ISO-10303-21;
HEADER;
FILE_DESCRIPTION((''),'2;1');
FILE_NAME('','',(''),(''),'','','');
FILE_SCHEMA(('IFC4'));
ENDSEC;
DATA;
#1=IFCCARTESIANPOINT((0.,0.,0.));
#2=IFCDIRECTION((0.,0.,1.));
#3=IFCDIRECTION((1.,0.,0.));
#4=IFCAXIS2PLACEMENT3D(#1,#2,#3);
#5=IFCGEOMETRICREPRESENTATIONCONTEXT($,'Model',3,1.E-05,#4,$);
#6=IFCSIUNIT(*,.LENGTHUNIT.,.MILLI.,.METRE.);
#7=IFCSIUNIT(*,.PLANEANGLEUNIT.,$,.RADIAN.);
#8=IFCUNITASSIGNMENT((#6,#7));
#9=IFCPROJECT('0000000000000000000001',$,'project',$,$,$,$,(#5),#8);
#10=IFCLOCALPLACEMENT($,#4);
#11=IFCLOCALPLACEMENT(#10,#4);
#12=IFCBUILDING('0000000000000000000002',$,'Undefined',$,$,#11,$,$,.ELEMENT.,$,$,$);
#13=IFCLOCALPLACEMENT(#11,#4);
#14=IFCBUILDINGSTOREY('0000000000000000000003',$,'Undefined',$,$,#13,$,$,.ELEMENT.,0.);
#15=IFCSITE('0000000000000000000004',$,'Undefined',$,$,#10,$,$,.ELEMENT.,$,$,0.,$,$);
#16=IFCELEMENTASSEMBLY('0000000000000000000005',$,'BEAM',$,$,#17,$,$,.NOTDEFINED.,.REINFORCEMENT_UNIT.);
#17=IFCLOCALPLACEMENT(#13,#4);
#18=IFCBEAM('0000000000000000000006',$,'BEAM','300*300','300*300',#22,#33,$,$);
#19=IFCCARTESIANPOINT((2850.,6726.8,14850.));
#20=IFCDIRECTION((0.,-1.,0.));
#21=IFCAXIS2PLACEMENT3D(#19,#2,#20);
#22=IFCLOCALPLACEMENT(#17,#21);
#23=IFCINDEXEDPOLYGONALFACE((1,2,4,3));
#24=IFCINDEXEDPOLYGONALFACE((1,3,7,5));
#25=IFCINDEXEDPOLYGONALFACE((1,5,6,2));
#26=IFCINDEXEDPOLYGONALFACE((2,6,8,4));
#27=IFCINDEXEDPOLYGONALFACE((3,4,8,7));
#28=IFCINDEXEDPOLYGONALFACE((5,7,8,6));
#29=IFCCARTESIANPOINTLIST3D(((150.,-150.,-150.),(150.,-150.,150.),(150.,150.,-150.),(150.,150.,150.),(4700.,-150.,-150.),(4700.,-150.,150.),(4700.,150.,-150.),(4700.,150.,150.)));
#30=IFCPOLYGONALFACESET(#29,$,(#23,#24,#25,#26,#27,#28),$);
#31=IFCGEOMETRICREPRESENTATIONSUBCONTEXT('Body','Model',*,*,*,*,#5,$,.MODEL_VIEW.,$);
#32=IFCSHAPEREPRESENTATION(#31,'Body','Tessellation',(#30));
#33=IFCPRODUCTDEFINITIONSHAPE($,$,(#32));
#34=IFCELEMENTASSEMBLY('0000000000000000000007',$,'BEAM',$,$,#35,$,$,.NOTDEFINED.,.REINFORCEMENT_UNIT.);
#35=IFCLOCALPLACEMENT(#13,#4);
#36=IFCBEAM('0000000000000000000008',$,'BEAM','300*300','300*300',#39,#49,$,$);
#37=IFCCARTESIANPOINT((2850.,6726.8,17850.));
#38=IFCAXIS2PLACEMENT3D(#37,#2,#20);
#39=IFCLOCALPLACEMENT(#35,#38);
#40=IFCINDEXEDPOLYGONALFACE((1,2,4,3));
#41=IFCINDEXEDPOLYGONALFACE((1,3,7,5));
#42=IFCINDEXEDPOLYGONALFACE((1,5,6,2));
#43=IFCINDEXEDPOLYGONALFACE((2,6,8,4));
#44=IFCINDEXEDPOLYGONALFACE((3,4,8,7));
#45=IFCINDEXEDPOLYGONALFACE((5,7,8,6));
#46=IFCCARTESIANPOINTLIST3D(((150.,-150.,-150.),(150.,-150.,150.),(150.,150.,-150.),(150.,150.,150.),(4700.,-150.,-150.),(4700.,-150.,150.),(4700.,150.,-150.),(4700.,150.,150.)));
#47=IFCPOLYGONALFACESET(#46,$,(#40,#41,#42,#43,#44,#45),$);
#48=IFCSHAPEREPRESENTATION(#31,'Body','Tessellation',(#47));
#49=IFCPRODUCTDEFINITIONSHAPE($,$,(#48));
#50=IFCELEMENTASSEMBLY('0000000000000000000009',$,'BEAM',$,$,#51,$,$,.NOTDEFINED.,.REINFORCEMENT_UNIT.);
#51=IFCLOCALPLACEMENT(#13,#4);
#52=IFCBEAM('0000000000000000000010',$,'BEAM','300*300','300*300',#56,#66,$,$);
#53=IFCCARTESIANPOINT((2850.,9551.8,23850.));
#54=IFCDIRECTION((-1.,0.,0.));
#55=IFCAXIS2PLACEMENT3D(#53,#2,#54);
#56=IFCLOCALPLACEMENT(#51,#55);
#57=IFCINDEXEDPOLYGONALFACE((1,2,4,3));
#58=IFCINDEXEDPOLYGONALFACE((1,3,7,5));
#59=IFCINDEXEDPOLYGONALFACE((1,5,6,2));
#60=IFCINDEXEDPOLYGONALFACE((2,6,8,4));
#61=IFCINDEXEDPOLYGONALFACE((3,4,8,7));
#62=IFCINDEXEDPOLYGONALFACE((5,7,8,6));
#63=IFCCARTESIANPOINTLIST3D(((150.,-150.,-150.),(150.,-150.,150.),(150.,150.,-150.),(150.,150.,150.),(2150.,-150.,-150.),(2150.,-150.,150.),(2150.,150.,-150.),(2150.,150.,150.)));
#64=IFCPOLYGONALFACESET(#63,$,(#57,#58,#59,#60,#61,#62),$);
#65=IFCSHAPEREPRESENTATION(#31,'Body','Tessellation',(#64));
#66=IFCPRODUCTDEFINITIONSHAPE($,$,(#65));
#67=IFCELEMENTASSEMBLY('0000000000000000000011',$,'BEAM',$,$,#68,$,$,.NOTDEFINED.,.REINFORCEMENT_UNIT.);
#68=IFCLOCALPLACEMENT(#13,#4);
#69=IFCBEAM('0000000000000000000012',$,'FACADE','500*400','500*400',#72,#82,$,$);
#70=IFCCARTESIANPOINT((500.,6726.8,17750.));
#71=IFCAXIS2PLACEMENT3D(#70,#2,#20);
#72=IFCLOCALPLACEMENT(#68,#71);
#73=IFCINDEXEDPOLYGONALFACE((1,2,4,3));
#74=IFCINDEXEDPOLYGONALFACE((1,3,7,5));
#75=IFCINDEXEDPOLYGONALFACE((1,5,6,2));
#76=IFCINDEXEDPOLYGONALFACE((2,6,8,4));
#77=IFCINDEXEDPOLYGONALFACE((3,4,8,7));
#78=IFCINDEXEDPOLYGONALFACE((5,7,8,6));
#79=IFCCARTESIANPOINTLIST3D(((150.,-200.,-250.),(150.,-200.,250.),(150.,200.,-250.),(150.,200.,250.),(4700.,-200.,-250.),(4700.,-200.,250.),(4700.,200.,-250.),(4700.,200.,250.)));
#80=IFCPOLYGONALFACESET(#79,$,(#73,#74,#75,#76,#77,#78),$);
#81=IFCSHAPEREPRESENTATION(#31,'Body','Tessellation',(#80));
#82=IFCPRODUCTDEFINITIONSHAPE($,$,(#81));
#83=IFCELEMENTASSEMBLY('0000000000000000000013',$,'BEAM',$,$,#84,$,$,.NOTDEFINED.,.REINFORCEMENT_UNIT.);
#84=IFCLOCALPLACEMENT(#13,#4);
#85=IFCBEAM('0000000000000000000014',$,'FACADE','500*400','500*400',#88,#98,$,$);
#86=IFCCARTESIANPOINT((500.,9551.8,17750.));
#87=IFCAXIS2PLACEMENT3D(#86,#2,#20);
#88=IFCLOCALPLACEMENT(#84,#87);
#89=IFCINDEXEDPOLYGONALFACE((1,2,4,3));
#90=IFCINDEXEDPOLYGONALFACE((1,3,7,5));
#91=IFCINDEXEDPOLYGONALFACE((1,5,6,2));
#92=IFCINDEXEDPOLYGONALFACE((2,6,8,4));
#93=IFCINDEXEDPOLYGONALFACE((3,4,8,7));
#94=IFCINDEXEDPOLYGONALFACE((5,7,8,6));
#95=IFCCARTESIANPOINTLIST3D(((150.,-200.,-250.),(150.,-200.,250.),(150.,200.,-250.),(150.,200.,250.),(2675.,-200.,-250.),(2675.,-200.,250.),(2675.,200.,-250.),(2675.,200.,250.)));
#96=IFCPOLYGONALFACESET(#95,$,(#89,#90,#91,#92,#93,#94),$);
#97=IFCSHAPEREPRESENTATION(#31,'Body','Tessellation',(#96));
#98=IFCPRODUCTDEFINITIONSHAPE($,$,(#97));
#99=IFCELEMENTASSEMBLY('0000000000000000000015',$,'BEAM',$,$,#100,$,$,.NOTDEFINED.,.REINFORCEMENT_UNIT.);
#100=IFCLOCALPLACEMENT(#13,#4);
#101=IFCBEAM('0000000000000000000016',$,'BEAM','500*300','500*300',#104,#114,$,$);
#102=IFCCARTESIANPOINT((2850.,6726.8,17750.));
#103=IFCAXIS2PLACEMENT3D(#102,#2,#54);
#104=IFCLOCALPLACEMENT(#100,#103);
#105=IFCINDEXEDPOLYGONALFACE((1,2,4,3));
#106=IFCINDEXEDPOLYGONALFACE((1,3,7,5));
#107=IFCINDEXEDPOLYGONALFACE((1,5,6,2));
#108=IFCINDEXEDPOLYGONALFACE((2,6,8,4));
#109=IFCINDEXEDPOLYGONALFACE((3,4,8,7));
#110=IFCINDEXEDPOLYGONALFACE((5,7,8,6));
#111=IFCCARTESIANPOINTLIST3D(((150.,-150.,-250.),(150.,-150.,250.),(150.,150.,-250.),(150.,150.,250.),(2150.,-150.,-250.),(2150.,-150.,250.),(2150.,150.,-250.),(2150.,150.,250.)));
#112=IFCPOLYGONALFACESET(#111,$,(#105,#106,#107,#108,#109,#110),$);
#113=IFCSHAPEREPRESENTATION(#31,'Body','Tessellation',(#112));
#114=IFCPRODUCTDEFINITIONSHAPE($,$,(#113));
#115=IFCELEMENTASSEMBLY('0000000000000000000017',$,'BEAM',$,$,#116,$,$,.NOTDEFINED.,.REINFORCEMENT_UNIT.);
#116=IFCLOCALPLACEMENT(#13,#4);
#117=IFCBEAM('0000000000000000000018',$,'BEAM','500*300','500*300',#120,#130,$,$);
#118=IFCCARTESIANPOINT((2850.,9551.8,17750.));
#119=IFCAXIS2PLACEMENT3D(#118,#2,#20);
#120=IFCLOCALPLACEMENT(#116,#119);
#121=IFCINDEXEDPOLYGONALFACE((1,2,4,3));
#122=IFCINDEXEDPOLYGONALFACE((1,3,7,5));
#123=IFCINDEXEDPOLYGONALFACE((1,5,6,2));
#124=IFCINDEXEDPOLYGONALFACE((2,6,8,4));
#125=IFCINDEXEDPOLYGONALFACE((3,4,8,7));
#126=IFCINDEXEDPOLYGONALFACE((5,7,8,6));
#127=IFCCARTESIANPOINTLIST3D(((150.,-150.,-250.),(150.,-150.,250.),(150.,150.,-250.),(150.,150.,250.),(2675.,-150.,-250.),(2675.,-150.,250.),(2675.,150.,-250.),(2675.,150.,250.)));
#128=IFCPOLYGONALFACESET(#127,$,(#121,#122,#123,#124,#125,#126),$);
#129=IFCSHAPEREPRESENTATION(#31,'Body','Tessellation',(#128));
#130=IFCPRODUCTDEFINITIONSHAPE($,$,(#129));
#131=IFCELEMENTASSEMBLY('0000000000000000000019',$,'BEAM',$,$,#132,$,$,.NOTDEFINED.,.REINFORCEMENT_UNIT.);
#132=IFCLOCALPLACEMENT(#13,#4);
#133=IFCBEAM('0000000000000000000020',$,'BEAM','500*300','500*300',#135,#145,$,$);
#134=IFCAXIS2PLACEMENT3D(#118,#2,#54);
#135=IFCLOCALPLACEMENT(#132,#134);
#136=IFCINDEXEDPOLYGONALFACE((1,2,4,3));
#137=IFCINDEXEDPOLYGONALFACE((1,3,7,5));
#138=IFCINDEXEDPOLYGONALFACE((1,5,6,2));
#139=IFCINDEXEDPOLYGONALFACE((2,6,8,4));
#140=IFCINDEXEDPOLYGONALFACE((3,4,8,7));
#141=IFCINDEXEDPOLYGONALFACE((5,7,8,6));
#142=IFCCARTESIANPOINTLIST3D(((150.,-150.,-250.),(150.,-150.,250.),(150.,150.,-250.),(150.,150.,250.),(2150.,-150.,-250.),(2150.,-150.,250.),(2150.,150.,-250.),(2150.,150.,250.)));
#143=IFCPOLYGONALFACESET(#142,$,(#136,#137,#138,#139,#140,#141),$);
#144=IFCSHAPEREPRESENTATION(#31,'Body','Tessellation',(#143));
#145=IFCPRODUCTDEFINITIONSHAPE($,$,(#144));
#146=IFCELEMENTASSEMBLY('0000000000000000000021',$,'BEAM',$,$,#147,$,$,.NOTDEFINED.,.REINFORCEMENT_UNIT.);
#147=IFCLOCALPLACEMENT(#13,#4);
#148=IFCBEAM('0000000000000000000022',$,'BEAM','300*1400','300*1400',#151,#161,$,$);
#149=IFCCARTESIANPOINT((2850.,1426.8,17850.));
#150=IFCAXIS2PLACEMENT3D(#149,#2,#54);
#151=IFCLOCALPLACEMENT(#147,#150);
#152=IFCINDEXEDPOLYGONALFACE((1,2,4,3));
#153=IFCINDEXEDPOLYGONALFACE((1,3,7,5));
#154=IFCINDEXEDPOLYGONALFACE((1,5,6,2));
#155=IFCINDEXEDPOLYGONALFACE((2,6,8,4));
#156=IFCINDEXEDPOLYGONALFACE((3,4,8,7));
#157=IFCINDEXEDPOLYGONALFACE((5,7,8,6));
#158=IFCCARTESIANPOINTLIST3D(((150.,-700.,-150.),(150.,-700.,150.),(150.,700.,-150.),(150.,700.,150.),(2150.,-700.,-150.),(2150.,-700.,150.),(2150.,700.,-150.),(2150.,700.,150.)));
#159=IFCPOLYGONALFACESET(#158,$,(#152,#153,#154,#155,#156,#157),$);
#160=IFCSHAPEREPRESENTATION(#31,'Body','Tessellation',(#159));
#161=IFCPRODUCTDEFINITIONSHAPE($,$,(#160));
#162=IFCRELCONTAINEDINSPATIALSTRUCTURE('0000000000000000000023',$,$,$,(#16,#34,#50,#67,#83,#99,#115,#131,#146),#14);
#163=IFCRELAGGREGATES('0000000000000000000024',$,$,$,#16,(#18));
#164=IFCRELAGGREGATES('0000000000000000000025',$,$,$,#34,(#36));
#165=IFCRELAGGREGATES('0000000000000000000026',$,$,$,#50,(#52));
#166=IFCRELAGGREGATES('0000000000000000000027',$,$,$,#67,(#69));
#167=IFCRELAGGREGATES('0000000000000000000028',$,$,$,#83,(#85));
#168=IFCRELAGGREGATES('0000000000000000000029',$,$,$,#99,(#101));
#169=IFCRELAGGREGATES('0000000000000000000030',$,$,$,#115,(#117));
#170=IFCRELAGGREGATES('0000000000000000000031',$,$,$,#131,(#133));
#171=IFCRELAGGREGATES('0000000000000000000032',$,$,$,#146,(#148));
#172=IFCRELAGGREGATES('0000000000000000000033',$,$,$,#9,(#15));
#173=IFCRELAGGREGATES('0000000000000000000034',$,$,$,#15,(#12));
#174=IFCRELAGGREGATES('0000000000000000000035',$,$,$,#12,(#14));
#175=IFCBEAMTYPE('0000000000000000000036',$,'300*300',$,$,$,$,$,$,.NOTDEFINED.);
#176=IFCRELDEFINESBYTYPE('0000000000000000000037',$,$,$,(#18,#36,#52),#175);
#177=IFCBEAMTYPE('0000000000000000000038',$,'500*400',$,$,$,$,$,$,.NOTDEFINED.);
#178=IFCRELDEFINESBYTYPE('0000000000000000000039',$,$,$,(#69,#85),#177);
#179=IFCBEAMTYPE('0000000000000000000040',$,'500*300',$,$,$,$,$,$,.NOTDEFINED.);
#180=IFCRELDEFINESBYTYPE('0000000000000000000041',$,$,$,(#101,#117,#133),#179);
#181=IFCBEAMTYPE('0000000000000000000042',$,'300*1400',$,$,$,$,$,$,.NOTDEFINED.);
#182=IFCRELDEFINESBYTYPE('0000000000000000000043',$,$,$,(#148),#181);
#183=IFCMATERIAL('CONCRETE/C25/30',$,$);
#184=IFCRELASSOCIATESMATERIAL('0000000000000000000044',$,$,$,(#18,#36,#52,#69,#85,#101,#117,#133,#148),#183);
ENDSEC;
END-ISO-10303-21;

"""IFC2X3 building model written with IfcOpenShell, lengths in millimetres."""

from ifc_helpers import new_model, si_unit, frame, origin_with_axes, origin_2d_with_axis, place, context, subcontext, project, spatial, rectangle, extrude, material, type_object, element, aggregate, save


model = new_model("IFC2X3")

# Units and contexts
model_context = context("Model", 3, precision=1e-05, world=origin_with_axes())
body_context = subcontext(model_context, "Body", "Model", "MODEL_VIEW")
ifc_project = project(units=[si_unit("LENGTHUNIT", "METRE", prefix="MILLI"), si_unit("PLANEANGLEUNIT", "RADIAN")], contexts=[model_context])

# Site, building, storey
site_placement = place(None, origin_with_axes())
site = spatial("IfcSite", under=ifc_project, at=site_placement, Name="Undefined", CompositionType="ELEMENT", RefElevation=0.0)
building_placement = place(site_placement, origin_with_axes())
building = spatial("IfcBuilding", under=site, at=building_placement, Name="Undefined", CompositionType="ELEMENT")
storey_placement = place(building_placement, origin_with_axes())
storey = spatial("IfcBuildingStorey", under=building, at=storey_placement, Name="Undefined", CompositionType="ELEMENT", Elevation=0.0)

# Shared definitions
ifc_material_1 = material(Name="CONCRETE/C25/30")

# Element assemblies, beams
assembly_1_placement = place(storey_placement, origin_with_axes())
assembly_1 = element("IfcElementAssembly", 1, at=assembly_1_placement, inside=storey, Name="BEAM", AssemblyPlace="NOTDEFINED", PredefinedType="REINFORCEMENT_UNIT")
beam_type_1 = type_object("IfcBeamType", Name="300*300", PredefinedType="NOTDEFINED")
beam_1_placement = place(assembly_1_placement, frame((2850.0, 6726.8, 14850.0), z_axis=(0.0, 0.0, 1.0), x_axis=(0.0, -1.0, 0.0)))
beam_1 = element("IfcBeam", 2, at=beam_1_placement, type_object=beam_type_1, material=ifc_material_1, Name="BEAM", Description="300*300", ObjectType="300*300", context=body_context, shape_type="SweptSolid", body=[
    extrude(rectangle(XDim=300.0, YDim=300.0, at=origin_2d_with_axis()), frame((4700.0, 0.0, 0.0), z_axis=(-1.0, 0.0, 0.0), x_axis=(0.0, -1.0, 0.0)), (0.0, 0.0, 1.0), 4550.0),
])
aggregate(assembly_1, [beam_1])
assembly_2_placement = place(storey_placement, origin_with_axes())
assembly_2 = element("IfcElementAssembly", 3, at=assembly_2_placement, inside=storey, Name="BEAM", AssemblyPlace="NOTDEFINED", PredefinedType="REINFORCEMENT_UNIT")
beam_2_placement = place(assembly_2_placement, frame((2850.0, 6726.8, 17850.0), z_axis=(0.0, 0.0, 1.0), x_axis=(0.0, -1.0, 0.0)))
beam_2 = element("IfcBeam", 4, at=beam_2_placement, type_object=beam_type_1, material=ifc_material_1, Name="BEAM", Description="300*300", ObjectType="300*300", context=body_context, shape_type="SweptSolid", body=[
    extrude(rectangle(XDim=300.0, YDim=300.0, at=origin_2d_with_axis()), frame((4700.0, 0.0, 0.0), z_axis=(-1.0, 0.0, 0.0), x_axis=(0.0, -1.0, 0.0)), (0.0, 0.0, 1.0), 4550.0),
])
aggregate(assembly_2, [beam_2])
assembly_3_placement = place(storey_placement, origin_with_axes())
assembly_3 = element("IfcElementAssembly", 5, at=assembly_3_placement, inside=storey, Name="BEAM", AssemblyPlace="NOTDEFINED", PredefinedType="REINFORCEMENT_UNIT")
beam_3_placement = place(assembly_3_placement, frame((2850.0, 9551.8, 23850.0), z_axis=(0.0, 0.0, 1.0), x_axis=(-1.0, 0.0, 0.0)))
beam_3 = element("IfcBeam", 6, at=beam_3_placement, type_object=beam_type_1, material=ifc_material_1, Name="BEAM", Description="300*300", ObjectType="300*300", context=body_context, shape_type="SweptSolid", body=[
    extrude(rectangle(XDim=300.0, YDim=300.0, at=origin_2d_with_axis()), frame((2150.0, 0.0, 0.0), z_axis=(-1.0, 0.0, 0.0), x_axis=(0.0, -1.0, 0.0)), (0.0, 0.0, 1.0), 2000.0),
])
aggregate(assembly_3, [beam_3])
assembly_4_placement = place(storey_placement, origin_with_axes())
assembly_4 = element("IfcElementAssembly", 7, at=assembly_4_placement, inside=storey, Name="BEAM", AssemblyPlace="NOTDEFINED", PredefinedType="REINFORCEMENT_UNIT")
beam_type_2 = type_object("IfcBeamType", Name="500*400", PredefinedType="NOTDEFINED")
beam_4_placement = place(assembly_4_placement, frame((500.0, 6726.8, 17750.0), z_axis=(0.0, 0.0, 1.0), x_axis=(0.0, -1.0, 0.0)))
beam_4 = element("IfcBeam", 8, at=beam_4_placement, type_object=beam_type_2, material=ifc_material_1, Name="FACADE", Description="500*400", ObjectType="500*400", context=body_context, shape_type="SweptSolid", body=[
    extrude(rectangle(XDim=400.0, YDim=500.0, at=origin_2d_with_axis()), frame((4700.0, 0.0, 0.0), z_axis=(-1.0, 0.0, 0.0), x_axis=(0.0, -1.0, 0.0)), (0.0, 0.0, 1.0), 4550.0),
])
aggregate(assembly_4, [beam_4])
assembly_5_placement = place(storey_placement, origin_with_axes())
assembly_5 = element("IfcElementAssembly", 9, at=assembly_5_placement, inside=storey, Name="BEAM", AssemblyPlace="NOTDEFINED", PredefinedType="REINFORCEMENT_UNIT")
beam_5_placement = place(assembly_5_placement, frame((500.0, 9551.8, 17750.0), z_axis=(0.0, 0.0, 1.0), x_axis=(0.0, -1.0, 0.0)))
beam_5 = element("IfcBeam", 10, at=beam_5_placement, type_object=beam_type_2, material=ifc_material_1, Name="FACADE", Description="500*400", ObjectType="500*400", context=body_context, shape_type="SweptSolid", body=[
    extrude(rectangle(XDim=400.0, YDim=500.0, at=origin_2d_with_axis()), frame((2675.0, 0.0, 0.0), z_axis=(-1.0, 0.0, 0.0), x_axis=(0.0, -1.0, 0.0)), (0.0, 0.0, 1.0), 2525.0),
])
aggregate(assembly_5, [beam_5])
assembly_6_placement = place(storey_placement, origin_with_axes())
assembly_6 = element("IfcElementAssembly", 11, at=assembly_6_placement, inside=storey, Name="BEAM", AssemblyPlace="NOTDEFINED", PredefinedType="REINFORCEMENT_UNIT")
beam_type_3 = type_object("IfcBeamType", Name="500*300", PredefinedType="NOTDEFINED")
beam_6_placement = place(assembly_6_placement, frame((2850.0, 6726.8, 17750.0), z_axis=(0.0, 0.0, 1.0), x_axis=(-1.0, 0.0, 0.0)))
beam_6 = element("IfcBeam", 12, at=beam_6_placement, type_object=beam_type_3, material=ifc_material_1, Name="BEAM", Description="500*300", ObjectType="500*300", context=body_context, shape_type="SweptSolid", body=[
    extrude(rectangle(XDim=300.0, YDim=500.0, at=origin_2d_with_axis()), frame((2150.0, 0.0, 0.0), z_axis=(-1.0, 0.0, 0.0), x_axis=(0.0, -1.0, 0.0)), (0.0, 0.0, 1.0), 2000.0),
])
aggregate(assembly_6, [beam_6])
assembly_7_placement = place(storey_placement, origin_with_axes())
assembly_7 = element("IfcElementAssembly", 13, at=assembly_7_placement, inside=storey, Name="BEAM", AssemblyPlace="NOTDEFINED", PredefinedType="REINFORCEMENT_UNIT")
beam_7_placement = place(assembly_7_placement, frame((2850.0, 9551.8, 17750.0), z_axis=(0.0, 0.0, 1.0), x_axis=(0.0, -1.0, 0.0)))
beam_7 = element("IfcBeam", 14, at=beam_7_placement, type_object=beam_type_3, material=ifc_material_1, Name="BEAM", Description="500*300", ObjectType="500*300", context=body_context, shape_type="SweptSolid", body=[
    extrude(rectangle(XDim=300.0, YDim=500.0, at=origin_2d_with_axis()), frame((2675.0, 0.0, 0.0), z_axis=(-1.0, 0.0, 0.0), x_axis=(0.0, -1.0, 0.0)), (0.0, 0.0, 1.0), 2525.0),
])
aggregate(assembly_7, [beam_7])
assembly_8_placement = place(storey_placement, origin_with_axes())
assembly_8 = element("IfcElementAssembly", 15, at=assembly_8_placement, inside=storey, Name="BEAM", AssemblyPlace="NOTDEFINED", PredefinedType="REINFORCEMENT_UNIT")
beam_8_placement = place(assembly_8_placement, frame((2850.0, 9551.8, 17750.0), z_axis=(0.0, 0.0, 1.0), x_axis=(-1.0, 0.0, 0.0)))
beam_8 = element("IfcBeam", 16, at=beam_8_placement, type_object=beam_type_3, material=ifc_material_1, Name="BEAM", Description="500*300", ObjectType="500*300", context=body_context, shape_type="SweptSolid", body=[
    extrude(rectangle(XDim=300.0, YDim=500.0, at=origin_2d_with_axis()), frame((2150.0, 0.0, 0.0), z_axis=(-1.0, 0.0, 0.0), x_axis=(0.0, -1.0, 0.0)), (0.0, 0.0, 1.0), 2000.0),
])
aggregate(assembly_8, [beam_8])
assembly_9_placement = place(storey_placement, origin_with_axes())
assembly_9 = element("IfcElementAssembly", 17, at=assembly_9_placement, inside=storey, Name="BEAM", AssemblyPlace="NOTDEFINED", PredefinedType="REINFORCEMENT_UNIT")
beam_type_4 = type_object("IfcBeamType", Name="300*1400", PredefinedType="NOTDEFINED")
beam_9_placement = place(assembly_9_placement, frame((2850.0, 1426.8, 17850.0), z_axis=(0.0, 0.0, 1.0), x_axis=(-1.0, 0.0, 0.0)))
beam_9 = element("IfcBeam", 18, at=beam_9_placement, type_object=beam_type_4, material=ifc_material_1, Name="BEAM", Description="300*1400", ObjectType="300*1400", context=body_context, shape_type="SweptSolid", body=[
    extrude(rectangle(XDim=1400.0, YDim=300.0, at=origin_2d_with_axis()), frame((2150.0, 0.0, 0.0), z_axis=(-1.0, 0.0, 0.0), x_axis=(0.0, -1.0, 0.0)), (0.0, 0.0, 1.0), 2000.0),
])
aggregate(assembly_9, [beam_9])

save(model, "model.ifc")
